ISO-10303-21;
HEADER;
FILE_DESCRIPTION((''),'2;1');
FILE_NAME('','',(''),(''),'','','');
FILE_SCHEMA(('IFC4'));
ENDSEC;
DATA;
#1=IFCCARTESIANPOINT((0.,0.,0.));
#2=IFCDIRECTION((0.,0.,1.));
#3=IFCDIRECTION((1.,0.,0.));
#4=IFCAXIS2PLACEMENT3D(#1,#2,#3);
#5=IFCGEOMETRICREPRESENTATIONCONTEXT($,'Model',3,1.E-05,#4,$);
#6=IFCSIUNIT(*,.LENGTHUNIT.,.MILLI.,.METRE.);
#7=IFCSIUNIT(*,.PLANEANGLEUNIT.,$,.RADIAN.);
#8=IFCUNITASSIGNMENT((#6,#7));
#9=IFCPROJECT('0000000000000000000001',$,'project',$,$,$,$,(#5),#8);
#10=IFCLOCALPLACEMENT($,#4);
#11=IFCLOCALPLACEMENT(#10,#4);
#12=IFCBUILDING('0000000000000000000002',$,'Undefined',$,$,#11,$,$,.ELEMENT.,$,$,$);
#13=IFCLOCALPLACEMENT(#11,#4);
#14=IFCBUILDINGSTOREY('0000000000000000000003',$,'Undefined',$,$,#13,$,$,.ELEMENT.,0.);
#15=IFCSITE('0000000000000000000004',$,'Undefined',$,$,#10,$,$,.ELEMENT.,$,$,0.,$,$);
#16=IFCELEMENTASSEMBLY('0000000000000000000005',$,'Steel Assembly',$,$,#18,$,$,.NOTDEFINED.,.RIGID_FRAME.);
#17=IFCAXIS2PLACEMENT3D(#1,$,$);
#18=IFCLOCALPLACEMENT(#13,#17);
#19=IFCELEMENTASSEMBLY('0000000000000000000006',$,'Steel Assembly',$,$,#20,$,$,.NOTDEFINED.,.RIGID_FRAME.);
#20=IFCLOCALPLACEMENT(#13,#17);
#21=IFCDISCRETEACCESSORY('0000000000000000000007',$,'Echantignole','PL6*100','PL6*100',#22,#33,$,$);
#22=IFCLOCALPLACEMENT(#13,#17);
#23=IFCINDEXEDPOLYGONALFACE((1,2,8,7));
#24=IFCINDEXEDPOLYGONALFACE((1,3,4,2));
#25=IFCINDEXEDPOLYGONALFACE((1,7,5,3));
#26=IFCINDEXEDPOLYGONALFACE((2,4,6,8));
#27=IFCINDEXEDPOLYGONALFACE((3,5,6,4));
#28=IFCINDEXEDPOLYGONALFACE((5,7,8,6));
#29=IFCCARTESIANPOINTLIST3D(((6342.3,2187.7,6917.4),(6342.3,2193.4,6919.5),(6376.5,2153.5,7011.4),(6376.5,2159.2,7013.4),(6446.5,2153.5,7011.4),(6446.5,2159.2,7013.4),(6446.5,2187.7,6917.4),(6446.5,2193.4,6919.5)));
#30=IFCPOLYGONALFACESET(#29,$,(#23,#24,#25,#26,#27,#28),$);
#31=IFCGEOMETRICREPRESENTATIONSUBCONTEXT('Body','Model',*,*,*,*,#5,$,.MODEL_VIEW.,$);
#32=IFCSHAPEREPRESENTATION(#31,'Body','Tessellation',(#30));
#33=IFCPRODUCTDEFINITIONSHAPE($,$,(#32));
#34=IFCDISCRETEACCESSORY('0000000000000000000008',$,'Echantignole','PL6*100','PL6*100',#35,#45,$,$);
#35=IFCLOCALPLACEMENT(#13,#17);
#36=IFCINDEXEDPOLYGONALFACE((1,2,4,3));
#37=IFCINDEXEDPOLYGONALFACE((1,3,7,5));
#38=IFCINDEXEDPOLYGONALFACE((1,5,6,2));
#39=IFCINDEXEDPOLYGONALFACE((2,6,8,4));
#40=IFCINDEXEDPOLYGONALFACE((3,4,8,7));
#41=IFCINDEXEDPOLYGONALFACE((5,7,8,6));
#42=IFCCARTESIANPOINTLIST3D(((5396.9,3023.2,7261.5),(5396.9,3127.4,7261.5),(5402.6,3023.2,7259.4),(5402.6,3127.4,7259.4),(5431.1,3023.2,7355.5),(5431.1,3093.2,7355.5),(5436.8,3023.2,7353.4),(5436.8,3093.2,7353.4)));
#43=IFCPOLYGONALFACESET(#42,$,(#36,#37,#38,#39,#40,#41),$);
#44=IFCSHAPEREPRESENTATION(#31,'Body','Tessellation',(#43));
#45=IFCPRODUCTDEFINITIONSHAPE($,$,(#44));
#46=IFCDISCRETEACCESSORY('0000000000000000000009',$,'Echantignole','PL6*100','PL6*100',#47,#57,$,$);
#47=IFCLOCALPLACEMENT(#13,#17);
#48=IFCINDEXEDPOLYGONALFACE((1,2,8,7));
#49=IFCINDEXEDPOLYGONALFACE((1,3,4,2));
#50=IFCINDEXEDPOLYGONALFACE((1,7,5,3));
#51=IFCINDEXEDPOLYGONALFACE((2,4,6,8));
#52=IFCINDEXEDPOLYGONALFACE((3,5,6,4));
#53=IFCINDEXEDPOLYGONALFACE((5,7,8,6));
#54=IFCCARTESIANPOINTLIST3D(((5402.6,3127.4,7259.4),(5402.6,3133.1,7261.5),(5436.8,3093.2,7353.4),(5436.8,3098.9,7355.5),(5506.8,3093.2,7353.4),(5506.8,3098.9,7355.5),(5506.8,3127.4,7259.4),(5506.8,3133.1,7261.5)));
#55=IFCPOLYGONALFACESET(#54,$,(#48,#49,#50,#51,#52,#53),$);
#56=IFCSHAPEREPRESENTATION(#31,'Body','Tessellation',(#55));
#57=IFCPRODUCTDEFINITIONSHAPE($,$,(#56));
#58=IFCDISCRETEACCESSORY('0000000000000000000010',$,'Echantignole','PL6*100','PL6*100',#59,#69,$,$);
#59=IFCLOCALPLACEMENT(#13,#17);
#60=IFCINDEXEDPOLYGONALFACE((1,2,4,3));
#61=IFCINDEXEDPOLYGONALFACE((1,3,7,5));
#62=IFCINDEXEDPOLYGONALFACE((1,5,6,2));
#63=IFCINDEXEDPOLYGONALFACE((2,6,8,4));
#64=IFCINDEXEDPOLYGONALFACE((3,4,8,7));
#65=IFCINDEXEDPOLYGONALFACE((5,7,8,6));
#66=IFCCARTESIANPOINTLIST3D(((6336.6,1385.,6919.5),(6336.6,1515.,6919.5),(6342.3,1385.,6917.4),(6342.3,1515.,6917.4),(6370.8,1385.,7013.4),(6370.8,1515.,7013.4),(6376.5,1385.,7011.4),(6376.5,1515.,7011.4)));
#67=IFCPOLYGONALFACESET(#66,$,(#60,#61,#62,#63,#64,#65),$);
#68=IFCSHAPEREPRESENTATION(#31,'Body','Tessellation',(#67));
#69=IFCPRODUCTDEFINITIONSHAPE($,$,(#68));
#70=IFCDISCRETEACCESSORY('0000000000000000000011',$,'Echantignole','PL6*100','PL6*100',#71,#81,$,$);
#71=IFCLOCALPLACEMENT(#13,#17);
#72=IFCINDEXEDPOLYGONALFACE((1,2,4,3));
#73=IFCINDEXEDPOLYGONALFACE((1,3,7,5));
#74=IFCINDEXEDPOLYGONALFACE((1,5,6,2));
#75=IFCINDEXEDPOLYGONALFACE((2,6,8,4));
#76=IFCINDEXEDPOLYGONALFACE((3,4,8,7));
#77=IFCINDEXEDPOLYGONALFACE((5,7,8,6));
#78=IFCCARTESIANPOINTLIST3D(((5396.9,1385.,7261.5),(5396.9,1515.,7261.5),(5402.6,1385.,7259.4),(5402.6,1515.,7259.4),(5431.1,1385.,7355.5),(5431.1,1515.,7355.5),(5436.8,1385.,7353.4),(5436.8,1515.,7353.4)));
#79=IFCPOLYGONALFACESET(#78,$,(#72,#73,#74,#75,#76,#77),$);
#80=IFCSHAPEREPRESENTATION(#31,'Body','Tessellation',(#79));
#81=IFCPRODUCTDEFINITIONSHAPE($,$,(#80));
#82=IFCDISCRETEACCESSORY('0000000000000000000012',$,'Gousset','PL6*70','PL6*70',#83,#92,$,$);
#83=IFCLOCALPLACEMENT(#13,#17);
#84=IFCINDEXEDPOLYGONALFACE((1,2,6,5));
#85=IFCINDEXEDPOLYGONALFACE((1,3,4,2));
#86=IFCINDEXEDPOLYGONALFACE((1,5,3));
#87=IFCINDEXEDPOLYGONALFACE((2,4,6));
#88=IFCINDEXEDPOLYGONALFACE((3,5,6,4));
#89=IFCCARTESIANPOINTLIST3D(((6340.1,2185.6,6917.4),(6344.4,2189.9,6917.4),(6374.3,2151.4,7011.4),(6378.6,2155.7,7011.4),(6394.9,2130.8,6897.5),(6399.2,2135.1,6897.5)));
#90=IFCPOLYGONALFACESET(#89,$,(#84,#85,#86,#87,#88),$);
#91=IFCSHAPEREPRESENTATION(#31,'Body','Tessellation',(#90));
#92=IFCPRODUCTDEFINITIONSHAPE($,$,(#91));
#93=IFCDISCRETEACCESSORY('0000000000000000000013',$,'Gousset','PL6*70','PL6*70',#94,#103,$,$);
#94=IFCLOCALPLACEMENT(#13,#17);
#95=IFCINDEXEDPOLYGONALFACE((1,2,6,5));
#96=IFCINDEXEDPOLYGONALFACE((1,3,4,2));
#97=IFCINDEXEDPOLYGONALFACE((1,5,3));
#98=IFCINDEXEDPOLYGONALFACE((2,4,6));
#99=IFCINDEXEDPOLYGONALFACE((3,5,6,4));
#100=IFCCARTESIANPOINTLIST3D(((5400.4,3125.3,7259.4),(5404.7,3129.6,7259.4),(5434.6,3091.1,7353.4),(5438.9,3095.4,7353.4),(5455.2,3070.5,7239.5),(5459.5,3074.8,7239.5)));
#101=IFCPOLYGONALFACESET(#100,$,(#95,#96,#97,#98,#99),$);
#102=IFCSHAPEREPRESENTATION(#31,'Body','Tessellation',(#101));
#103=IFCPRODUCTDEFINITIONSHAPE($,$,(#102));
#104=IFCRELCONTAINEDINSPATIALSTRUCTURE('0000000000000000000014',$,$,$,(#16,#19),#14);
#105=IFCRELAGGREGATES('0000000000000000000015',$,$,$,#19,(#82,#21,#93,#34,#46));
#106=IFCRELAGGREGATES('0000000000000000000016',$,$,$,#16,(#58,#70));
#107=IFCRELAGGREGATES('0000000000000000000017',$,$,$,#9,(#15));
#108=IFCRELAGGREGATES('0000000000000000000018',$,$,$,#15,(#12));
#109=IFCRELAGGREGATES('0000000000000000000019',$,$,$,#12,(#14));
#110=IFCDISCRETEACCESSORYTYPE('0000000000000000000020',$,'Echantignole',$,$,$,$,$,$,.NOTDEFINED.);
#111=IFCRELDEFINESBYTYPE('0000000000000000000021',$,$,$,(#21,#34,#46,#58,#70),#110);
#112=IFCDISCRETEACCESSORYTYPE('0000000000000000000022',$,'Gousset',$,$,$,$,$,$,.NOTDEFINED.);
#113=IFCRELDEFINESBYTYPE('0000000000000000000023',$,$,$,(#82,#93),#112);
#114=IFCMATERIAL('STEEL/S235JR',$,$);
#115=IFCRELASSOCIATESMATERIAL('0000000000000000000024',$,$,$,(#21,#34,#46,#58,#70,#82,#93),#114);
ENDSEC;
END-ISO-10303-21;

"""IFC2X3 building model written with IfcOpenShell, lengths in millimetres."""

from ifc_helpers import new_model, si_unit, frame, origin_with_axes, place, context, subcontext, project, spatial, polyline, outline, extrude, material, type_object, element, aggregate, save


model = new_model("IFC2X3")

# Units and contexts
model_context = context("Model", 3, precision=1e-05, world=origin_with_axes())
body_context = subcontext(model_context, "Body", "Model", "MODEL_VIEW")
ifc_project = project(units=[si_unit("LENGTHUNIT", "METRE", prefix="MILLI"), si_unit("PLANEANGLEUNIT", "RADIAN")], contexts=[model_context])

# Site, building, storey
site_placement = place(None, origin_with_axes())
site = spatial("IfcSite", under=ifc_project, at=site_placement, Name="Undefined", CompositionType="ELEMENT", RefElevation=0.0)
building_placement = place(site_placement, origin_with_axes())
building = spatial("IfcBuilding", under=site, at=building_placement, Name="Undefined", CompositionType="ELEMENT")
storey_placement = place(building_placement, origin_with_axes())
storey = spatial("IfcBuildingStorey", under=building, at=storey_placement, Name="Undefined", CompositionType="ELEMENT", Elevation=0.0)

# Shared definitions
ifc_material_1 = material(Name="STEEL/S235JR")

# Element assembly
assembly_1_placement = place(storey_placement, origin_with_axes())
assembly_1 = element("IfcElementAssembly", 1, at=assembly_1_placement, inside=storey, Name="Steel Assembly", AssemblyPlace="NOTDEFINED", PredefinedType="RIGID_FRAME")

# Shared definitions
discrete_accessory_type_1 = type_object("IfcDiscreteAccessoryType", Name="Echantignole")

# Element assembly, discrete accessories
assembly_2_placement = place(storey_placement, origin_with_axes())
assembly_2 = element("IfcElementAssembly", 2, at=assembly_2_placement, inside=storey, Name="Steel Assembly", AssemblyPlace="NOTDEFINED", PredefinedType="RIGID_FRAME")
discrete_accessory_1_placement = place(assembly_2_placement, frame((6376.5, 2156.4, 7012.4), z_axis=(0.0, 0.939693, 0.34202), x_axis=(1.0, 0.0, 0.0)))
discrete_accessory_1 = element("IfcDiscreteAccessory", 3, at=discrete_accessory_1_placement, type_object=discrete_accessory_type_1, material=ifc_material_1, Name="Echantignole", Description="PL6*100", ObjectType="PL6*100", context=body_context, shape_type="SweptSolid", body=[
    extrude(outline(polyline([(0.0, 0.0), (70.0, 0.0), (70.0, 100.0), (-34.2, 100.0), (0.0, 0.0)])), frame((0.0, 0.0, -3.0), z_axis=(0.0, 0.0, 1.0), x_axis=(1.0, 0.0, 0.0)), (0.0, 0.0, 1.0), 6.0),
])
discrete_accessory_2_placement = place(assembly_2_placement, frame((5433.9, 3093.2, 7354.4), z_axis=(0.939693, 0.0, -0.34202), x_axis=(0.0, -1.0, 0.0)))
discrete_accessory_2 = element("IfcDiscreteAccessory", 4, at=discrete_accessory_2_placement, type_object=discrete_accessory_type_1, material=ifc_material_1, Name="Echantignole", Description="PL6*100", ObjectType="PL6*100", context=body_context, shape_type="SweptSolid", body=[
    extrude(outline(polyline([(0.0, 0.0), (70.0, 0.0), (70.0, 100.0), (-34.2, 100.0), (0.0, 0.0)])), frame((0.0, 0.0, -3.0), z_axis=(0.0, 0.0, 1.0), x_axis=(1.0, 0.0, 0.0)), (0.0, 0.0, 1.0), 6.0),
])
discrete_accessory_3_placement = place(assembly_2_placement, frame((5436.8, 3096.1, 7354.4), z_axis=(0.0, 0.939693, 0.34202), x_axis=(1.0, 0.0, 0.0)))
discrete_accessory_3 = element("IfcDiscreteAccessory", 5, at=discrete_accessory_3_placement, type_object=discrete_accessory_type_1, material=ifc_material_1, Name="Echantignole", Description="PL6*100", ObjectType="PL6*100", context=body_context, shape_type="SweptSolid", body=[
    extrude(outline(polyline([(0.0, 0.0), (70.0, 0.0), (70.0, 100.0), (-34.2, 100.0), (0.0, 0.0)])), frame((0.0, 0.0, -3.0), z_axis=(0.0, 0.0, 1.0), x_axis=(1.0, 0.0, 0.0)), (0.0, 0.0, 1.0), 6.0),
])

# Discrete accessories
discrete_accessory_4_placement = place(assembly_1_placement, frame((6356.5, 1385.0, 6965.4), z_axis=(0.939693, 0.0, -0.34202), x_axis=(0.0, 1.0, 0.0)))
discrete_accessory_4 = element("IfcDiscreteAccessory", 6, at=discrete_accessory_4_placement, type_object=discrete_accessory_type_1, material=ifc_material_1, Name="Echantignole", Description="PL6*100", ObjectType="PL6*100", context=body_context, shape_type="SweptSolid", body=[
    extrude(outline(polyline([(0.0, 50.0), (130.0, 50.0), (130.0, -50.0), (0.0, -50.0), (0.0, 50.0)])), frame((0.0, 0.0, -3.0), z_axis=(0.0, 0.0, 1.0), x_axis=(1.0, 0.0, 0.0)), (0.0, 0.0, 1.0), 6.0),
])
discrete_accessory_5_placement = place(assembly_1_placement, frame((5416.8, 1385.0, 7307.5), z_axis=(0.939693, 0.0, -0.34202), x_axis=(0.0, 1.0, 0.0)))
discrete_accessory_5 = element("IfcDiscreteAccessory", 7, at=discrete_accessory_5_placement, type_object=discrete_accessory_type_1, material=ifc_material_1, Name="Echantignole", Description="PL6*100", ObjectType="PL6*100", context=body_context, shape_type="SweptSolid", body=[
    extrude(outline(polyline([(0.0, 50.0), (130.0, 50.0), (130.0, -50.0), (0.0, -50.0), (0.0, 50.0)])), frame((0.0, 0.0, -3.0), z_axis=(0.0, 0.0, 1.0), x_axis=(1.0, 0.0, 0.0)), (0.0, 0.0, 1.0), 6.0),
])
discrete_accessory_type_2 = type_object("IfcDiscreteAccessoryType", Name="Gousset")
discrete_accessory_6_placement = place(assembly_2_placement, frame((6376.5, 2153.5, 7011.4), z_axis=(-0.707107, -0.707107, 0.0), x_axis=(-0.323616, 0.323616, -0.889126)))
discrete_accessory_6 = element("IfcDiscreteAccessory", 8, at=discrete_accessory_6_placement, type_object=discrete_accessory_type_2, material=ifc_material_1, Name="Gousset", Description="PL6*70", ObjectType="PL6*70", context=body_context, shape_type="SweptSolid", body=[
    extrude(outline(polyline([(0.0, 0.0), (105.7, 0.0), (88.0, 78.0), (0.0, 0.0)])), frame((0.0, 0.0, -3.0), z_axis=(0.0, 0.0, 1.0), x_axis=(1.0, 0.0, 0.0)), (0.0, 0.0, 1.0), 6.0),
])
discrete_accessory_7_placement = place(assembly_2_placement, frame((5436.8, 3093.2, 7353.4), z_axis=(-0.707107, -0.707107, 0.0), x_axis=(-0.323616, 0.323616, -0.889126)))
discrete_accessory_7 = element("IfcDiscreteAccessory", 9, at=discrete_accessory_7_placement, type_object=discrete_accessory_type_2, material=ifc_material_1, Name="Gousset", Description="PL6*70", ObjectType="PL6*70", context=body_context, shape_type="SweptSolid", body=[
    extrude(outline(polyline([(0.0, 0.0), (105.7, 0.0), (88.0, 78.0), (0.0, 0.0)])), frame((0.0, 0.0, -3.0), z_axis=(0.0, 0.0, 1.0), x_axis=(1.0, 0.0, 0.0)), (0.0, 0.0, 1.0), 6.0),
])
aggregate(assembly_2, [discrete_accessory_6, discrete_accessory_1, discrete_accessory_7, discrete_accessory_2, discrete_accessory_3])

aggregate(assembly_1, [discrete_accessory_4, discrete_accessory_5])

save(model, "model.ifc")
